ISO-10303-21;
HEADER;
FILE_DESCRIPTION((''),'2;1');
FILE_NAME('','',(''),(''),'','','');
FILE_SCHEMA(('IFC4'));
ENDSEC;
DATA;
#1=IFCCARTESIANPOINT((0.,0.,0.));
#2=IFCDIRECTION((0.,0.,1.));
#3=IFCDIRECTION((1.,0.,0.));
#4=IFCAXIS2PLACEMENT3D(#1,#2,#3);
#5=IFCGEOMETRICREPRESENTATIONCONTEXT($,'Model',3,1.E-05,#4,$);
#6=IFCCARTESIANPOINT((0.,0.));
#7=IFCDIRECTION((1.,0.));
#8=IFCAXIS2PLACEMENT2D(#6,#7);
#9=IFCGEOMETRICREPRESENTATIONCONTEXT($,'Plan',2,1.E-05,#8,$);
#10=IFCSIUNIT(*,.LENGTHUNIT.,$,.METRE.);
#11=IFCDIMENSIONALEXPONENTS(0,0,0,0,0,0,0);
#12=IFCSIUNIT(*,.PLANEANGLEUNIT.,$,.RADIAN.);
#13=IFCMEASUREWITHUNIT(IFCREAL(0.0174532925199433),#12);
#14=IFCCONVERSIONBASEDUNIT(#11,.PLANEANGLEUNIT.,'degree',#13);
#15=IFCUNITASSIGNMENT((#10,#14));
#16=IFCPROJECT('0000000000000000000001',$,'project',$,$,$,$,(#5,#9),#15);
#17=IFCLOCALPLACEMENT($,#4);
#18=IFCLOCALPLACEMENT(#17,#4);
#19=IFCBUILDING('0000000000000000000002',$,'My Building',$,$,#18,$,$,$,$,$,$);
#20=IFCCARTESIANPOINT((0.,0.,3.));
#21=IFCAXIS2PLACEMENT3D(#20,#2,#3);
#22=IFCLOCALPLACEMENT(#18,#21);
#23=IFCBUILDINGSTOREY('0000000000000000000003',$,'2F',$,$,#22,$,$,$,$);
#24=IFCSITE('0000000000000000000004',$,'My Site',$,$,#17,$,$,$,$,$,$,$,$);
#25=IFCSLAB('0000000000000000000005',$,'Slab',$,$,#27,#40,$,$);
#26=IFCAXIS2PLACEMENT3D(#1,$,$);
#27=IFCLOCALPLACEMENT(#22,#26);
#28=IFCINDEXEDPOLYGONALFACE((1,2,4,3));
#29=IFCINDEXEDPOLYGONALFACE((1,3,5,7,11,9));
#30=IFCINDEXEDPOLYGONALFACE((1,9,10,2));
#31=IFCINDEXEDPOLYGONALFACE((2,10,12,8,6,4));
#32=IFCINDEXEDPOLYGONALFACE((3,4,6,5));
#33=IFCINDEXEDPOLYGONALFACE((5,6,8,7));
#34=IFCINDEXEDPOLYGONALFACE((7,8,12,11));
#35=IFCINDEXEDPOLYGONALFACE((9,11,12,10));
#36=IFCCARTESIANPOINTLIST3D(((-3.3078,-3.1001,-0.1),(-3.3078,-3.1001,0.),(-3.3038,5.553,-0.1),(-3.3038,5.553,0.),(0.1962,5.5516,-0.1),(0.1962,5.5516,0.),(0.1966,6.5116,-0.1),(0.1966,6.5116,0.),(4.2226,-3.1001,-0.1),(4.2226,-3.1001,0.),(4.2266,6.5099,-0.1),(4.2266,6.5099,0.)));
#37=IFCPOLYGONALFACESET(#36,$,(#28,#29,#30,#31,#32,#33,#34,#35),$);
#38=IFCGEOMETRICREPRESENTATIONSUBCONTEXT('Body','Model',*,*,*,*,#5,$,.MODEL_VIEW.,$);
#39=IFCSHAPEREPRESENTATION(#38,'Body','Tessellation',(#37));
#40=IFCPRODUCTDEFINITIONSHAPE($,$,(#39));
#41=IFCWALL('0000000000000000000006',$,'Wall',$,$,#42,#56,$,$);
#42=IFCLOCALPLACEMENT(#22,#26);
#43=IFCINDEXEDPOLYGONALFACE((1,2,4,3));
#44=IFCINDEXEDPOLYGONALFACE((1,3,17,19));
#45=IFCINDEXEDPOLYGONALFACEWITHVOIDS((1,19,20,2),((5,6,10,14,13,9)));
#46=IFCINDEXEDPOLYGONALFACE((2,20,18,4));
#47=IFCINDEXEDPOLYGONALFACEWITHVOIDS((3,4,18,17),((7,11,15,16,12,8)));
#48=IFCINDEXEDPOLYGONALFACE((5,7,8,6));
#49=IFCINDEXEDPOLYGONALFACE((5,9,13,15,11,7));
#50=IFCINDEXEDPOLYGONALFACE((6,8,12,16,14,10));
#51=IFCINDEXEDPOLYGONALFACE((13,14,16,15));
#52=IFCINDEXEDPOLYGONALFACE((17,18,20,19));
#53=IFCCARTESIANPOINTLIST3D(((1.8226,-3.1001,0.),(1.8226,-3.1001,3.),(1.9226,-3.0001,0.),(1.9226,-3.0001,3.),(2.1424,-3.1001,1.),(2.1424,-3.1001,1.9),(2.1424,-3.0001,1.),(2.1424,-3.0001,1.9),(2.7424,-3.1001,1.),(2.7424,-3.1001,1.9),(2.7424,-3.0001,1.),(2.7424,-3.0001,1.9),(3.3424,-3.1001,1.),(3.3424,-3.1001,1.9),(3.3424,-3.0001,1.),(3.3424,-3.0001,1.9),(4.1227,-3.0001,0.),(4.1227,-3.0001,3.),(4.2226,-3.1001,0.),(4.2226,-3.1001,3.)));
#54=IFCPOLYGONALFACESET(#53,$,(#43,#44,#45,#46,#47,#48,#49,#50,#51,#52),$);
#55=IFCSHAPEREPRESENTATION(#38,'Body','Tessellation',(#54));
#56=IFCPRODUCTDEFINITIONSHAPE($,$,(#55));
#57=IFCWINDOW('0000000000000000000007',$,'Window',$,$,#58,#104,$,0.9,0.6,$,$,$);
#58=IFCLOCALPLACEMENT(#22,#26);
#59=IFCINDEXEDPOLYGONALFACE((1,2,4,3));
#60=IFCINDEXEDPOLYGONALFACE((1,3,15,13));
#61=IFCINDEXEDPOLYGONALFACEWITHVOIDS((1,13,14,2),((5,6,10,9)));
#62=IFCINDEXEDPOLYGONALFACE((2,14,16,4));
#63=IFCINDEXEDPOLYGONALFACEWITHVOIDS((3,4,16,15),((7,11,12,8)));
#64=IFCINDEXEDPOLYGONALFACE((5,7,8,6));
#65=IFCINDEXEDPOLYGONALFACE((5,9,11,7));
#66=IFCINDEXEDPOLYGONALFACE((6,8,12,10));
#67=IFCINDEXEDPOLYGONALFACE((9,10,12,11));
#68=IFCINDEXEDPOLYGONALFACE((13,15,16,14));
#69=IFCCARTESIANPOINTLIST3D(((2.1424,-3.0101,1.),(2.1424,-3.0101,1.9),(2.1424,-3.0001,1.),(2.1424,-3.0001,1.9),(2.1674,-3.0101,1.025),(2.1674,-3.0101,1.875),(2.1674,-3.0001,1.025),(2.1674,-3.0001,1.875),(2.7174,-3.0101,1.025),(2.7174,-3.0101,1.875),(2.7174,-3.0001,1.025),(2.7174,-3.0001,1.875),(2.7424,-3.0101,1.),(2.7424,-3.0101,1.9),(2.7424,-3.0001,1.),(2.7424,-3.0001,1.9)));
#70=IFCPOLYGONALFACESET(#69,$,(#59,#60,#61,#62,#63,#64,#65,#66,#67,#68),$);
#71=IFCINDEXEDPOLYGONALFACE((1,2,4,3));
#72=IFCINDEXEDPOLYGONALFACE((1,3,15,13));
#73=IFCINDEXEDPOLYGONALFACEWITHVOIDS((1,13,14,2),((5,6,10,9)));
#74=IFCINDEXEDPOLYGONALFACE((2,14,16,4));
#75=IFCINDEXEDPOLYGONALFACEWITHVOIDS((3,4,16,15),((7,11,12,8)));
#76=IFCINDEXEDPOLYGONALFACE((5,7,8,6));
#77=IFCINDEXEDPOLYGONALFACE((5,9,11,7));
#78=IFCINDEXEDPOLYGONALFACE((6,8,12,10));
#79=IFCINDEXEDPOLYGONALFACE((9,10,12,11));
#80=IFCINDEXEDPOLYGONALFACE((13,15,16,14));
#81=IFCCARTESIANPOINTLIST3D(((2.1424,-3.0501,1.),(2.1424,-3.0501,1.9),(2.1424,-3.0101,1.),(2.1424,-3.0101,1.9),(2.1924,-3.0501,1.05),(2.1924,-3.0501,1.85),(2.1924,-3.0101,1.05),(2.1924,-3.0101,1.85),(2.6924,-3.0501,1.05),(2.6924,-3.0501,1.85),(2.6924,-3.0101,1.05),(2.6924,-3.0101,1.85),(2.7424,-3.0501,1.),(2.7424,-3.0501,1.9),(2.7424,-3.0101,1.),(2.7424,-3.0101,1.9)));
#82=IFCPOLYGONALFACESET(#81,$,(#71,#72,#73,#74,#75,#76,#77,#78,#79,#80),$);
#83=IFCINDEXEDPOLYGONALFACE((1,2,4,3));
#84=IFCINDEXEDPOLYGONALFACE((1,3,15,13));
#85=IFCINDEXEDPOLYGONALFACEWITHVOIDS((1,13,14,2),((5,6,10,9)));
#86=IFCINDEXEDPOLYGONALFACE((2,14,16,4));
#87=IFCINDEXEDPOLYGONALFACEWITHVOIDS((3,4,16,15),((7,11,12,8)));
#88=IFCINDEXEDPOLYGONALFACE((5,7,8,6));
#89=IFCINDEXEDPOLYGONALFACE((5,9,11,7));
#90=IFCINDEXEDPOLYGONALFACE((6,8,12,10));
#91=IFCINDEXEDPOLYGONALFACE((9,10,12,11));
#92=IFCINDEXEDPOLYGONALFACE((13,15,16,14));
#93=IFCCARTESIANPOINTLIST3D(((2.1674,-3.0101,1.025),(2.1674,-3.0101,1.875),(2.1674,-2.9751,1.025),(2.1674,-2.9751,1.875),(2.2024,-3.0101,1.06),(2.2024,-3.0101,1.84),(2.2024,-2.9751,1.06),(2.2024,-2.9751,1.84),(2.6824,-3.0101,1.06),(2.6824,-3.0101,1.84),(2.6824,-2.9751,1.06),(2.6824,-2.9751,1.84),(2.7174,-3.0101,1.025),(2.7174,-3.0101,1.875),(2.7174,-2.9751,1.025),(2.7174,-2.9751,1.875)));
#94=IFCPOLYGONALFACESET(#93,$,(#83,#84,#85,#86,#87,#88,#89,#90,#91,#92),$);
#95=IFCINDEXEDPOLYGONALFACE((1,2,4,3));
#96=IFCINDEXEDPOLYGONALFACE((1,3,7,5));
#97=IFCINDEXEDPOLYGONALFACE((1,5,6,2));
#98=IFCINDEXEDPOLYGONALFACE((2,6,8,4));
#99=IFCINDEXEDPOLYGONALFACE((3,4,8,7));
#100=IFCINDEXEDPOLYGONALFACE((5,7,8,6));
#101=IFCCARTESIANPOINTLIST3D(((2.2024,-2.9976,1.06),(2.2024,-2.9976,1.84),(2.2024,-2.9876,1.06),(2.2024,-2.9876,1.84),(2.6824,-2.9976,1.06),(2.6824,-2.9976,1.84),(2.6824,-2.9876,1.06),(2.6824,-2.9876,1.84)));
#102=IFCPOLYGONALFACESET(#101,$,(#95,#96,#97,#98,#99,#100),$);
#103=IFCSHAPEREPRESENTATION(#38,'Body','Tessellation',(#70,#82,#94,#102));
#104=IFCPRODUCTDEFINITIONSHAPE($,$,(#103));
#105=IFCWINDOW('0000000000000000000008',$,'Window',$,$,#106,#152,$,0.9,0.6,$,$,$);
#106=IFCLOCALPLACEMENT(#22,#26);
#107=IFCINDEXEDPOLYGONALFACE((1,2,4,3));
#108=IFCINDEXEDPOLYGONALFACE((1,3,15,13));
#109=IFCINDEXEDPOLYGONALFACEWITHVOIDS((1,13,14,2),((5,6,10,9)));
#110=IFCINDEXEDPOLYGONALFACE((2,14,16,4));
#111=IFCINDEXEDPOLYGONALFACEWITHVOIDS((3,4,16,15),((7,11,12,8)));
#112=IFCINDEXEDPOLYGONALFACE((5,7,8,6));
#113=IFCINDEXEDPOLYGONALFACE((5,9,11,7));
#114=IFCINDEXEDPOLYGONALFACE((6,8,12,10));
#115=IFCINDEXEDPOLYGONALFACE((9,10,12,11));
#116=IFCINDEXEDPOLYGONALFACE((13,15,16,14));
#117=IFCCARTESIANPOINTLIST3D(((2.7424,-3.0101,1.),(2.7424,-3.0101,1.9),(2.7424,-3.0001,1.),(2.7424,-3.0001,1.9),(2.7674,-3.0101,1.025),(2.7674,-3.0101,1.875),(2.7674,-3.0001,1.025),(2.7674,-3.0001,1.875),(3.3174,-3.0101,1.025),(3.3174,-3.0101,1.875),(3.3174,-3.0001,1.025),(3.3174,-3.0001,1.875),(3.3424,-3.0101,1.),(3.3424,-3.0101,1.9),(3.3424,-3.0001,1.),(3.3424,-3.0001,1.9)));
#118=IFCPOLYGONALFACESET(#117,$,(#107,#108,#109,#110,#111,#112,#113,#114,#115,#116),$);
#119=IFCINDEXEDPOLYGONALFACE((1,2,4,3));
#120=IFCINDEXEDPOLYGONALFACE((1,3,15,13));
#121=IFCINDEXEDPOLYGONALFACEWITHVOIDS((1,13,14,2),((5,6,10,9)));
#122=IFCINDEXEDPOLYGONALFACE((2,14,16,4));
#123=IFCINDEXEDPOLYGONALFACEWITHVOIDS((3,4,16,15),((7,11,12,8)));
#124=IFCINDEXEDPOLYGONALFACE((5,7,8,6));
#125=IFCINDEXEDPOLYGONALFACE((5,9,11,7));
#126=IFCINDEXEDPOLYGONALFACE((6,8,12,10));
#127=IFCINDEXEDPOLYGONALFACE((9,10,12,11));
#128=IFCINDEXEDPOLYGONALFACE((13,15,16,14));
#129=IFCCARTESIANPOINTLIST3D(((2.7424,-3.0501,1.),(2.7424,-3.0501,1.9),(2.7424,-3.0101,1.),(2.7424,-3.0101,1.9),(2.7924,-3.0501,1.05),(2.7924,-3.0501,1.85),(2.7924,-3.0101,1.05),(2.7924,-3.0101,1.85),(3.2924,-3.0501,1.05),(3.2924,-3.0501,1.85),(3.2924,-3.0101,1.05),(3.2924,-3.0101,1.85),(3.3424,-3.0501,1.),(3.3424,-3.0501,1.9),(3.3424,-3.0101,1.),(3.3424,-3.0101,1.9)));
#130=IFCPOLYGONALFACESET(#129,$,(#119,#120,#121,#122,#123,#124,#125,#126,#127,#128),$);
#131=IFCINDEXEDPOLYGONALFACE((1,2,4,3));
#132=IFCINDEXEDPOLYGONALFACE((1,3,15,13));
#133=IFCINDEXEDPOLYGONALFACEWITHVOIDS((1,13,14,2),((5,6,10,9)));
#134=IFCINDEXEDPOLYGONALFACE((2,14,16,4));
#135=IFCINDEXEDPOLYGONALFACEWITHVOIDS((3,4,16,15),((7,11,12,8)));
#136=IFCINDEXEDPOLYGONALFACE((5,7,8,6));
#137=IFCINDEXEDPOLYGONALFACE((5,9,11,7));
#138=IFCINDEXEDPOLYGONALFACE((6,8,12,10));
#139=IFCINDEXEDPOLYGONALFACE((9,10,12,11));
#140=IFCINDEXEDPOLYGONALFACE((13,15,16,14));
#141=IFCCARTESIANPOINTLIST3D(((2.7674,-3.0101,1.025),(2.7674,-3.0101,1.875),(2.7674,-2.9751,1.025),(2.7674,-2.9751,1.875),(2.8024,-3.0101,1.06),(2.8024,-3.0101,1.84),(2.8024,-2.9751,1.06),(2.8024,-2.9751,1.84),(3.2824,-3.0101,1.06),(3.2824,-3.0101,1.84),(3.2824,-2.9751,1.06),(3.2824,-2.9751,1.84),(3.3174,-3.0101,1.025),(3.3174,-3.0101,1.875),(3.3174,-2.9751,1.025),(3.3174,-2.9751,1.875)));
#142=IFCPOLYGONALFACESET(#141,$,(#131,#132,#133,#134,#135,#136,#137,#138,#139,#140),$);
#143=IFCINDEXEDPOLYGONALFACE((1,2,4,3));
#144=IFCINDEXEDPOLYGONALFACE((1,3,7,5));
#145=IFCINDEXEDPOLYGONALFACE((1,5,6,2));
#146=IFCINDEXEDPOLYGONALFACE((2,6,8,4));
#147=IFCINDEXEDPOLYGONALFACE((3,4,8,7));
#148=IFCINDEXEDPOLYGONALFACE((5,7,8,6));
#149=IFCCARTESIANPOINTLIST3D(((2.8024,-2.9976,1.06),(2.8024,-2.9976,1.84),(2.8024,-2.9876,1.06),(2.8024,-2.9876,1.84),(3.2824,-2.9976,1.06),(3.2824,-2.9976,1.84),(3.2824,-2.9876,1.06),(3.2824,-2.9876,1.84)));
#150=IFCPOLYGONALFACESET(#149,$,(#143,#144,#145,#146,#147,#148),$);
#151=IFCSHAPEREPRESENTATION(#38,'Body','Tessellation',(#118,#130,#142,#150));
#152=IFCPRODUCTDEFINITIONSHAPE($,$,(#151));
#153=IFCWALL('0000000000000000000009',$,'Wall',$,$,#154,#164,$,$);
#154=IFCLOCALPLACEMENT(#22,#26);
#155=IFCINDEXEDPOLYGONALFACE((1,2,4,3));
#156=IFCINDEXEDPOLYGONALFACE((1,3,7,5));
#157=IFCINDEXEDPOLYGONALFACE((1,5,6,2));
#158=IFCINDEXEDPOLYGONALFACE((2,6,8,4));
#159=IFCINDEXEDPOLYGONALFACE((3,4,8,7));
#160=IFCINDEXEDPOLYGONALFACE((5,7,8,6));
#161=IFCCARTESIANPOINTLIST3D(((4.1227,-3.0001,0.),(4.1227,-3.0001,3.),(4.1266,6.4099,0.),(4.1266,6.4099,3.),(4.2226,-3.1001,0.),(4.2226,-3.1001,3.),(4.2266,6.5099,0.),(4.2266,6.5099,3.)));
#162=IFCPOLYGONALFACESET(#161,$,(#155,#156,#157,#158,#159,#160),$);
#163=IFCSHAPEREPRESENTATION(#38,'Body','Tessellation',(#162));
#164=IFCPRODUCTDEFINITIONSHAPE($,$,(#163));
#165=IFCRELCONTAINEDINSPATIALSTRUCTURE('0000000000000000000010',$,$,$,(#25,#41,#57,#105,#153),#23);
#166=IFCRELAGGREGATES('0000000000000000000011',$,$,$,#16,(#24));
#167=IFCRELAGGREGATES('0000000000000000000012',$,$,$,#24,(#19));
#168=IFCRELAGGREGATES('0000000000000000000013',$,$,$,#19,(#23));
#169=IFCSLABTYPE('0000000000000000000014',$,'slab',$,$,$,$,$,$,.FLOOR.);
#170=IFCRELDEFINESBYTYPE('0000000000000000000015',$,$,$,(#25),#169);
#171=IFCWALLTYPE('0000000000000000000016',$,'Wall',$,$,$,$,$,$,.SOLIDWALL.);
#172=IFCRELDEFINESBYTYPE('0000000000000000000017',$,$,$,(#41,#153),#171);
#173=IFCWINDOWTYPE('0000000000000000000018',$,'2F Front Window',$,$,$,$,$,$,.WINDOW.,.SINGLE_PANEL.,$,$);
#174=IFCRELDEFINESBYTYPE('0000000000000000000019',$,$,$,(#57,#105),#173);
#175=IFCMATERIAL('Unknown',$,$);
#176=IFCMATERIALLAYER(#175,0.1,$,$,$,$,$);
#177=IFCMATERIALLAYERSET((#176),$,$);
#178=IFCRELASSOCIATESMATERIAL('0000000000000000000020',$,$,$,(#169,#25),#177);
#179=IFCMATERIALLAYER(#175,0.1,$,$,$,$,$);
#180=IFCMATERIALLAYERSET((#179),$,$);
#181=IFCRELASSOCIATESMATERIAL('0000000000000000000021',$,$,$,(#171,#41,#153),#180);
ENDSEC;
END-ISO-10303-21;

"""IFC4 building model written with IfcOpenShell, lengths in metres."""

from ifc_helpers import new_model, entity, si_unit, converted_unit, frame, origin_with_axes, origin_2d_with_axis, place, context, subcontext, project, spatial, line, indexed_curve, outline, extrude, shape, source, transform, mapped, material, layer, layer_set, layer_usage, type_object, type_shapes, element, fill, save


model = new_model("IFC4")

# Units and contexts
model_context = context("Model", 3, precision=1e-05, world=origin_with_axes())
plan_context = context("Plan", 2, precision=1e-05, world=origin_2d_with_axis())
body_context_1 = subcontext(model_context, "Body", "Model", "MODEL_VIEW")
body_context_2 = subcontext(plan_context, "Body", "Plan", "PLAN_VIEW")
ifc_project = project(units=[si_unit("LENGTHUNIT", "METRE"), converted_unit("PLANEANGLEUNIT", "degree", entity("IfcReal", 0.0174532925199433), si_unit("PLANEANGLEUNIT", "RADIAN"), dimensions=[0, 0, 0, 0, 0, 0, 0])], contexts=[model_context, plan_context])

# Site, building, storey
site_placement = place(None, origin_with_axes())
site = spatial("IfcSite", under=ifc_project, at=site_placement, Name="My Site")
building_placement = place(site_placement, origin_with_axes())
building = spatial("IfcBuilding", under=site, at=building_placement, Name="My Building")
storey_placement = place(building_placement, frame((0.0, 0.0, 3.0), z_axis=(0.0, 0.0, 1.0), x_axis=(1.0, 0.0, 0.0)))
storey = spatial("IfcBuildingStorey", under=building, at=storey_placement, Name="2F")

# Slab
ifc_material = material(Name="Unknown")
ifc_layer_1 = layer(ifc_material, 0.1)
ifc_layer_set_1 = layer_set([ifc_layer_1])
ifc_layer_usage_1 = layer_usage(ifc_layer_set_1, "AXIS3", "POSITIVE", -0.1)
slab_type = type_object("IfcSlabType", Name="slab", PredefinedType="FLOOR", material=ifc_layer_set_1)
slab_placement = place(storey_placement, frame((-3.3078, -3.1001, 0.0), z_axis=(0.0, 0.0, 1.0), x_axis=(1.0, 0.0, 0.0)))
element("IfcSlab", 1, at=slab_placement, inside=storey, type_object=slab_type, material=ifc_layer_usage_1, Name="Slab", context=body_context_1, shape_type="SweptSolid", body=[
    extrude(outline(indexed_curve([(0.0, 0.0), (7.5304, 0.0), (7.5344, 9.61), (3.5044, 9.6117), (3.504, 8.6517), (0.004, 8.6531), (0.0, 0.0)])), frame((0.0, 0.0, -0.1), z_axis=(0.0, 0.0, 1.0), x_axis=(1.0, 0.0, 0.0)), (0.0, 0.0, 1.0), 0.1),
])

# Wall, openings, windows
ifc_layer_2 = layer(ifc_material, 0.1)
ifc_layer_set_2 = layer_set([ifc_layer_2])
ifc_layer_usage_2 = layer_usage(ifc_layer_set_2, "AXIS2", "POSITIVE", 0.0)
wall_type = type_object("IfcWallType", Name="Wall", PredefinedType="SOLIDWALL", material=ifc_layer_set_2)
wall_1_placement = place(storey_placement, frame((1.8226, -3.1001, 0.0), z_axis=(0.0, 0.0, 1.0), x_axis=(1.0, 0.0, 0.0)))
wall_1 = element("IfcWall", 2, at=wall_1_placement, inside=storey, type_object=wall_type, material=ifc_layer_usage_2, Name="Wall", context=body_context_1, shape_type="SweptSolid", body=[
    extrude(outline(indexed_curve([(0.0, 0.0), (0.1, 0.1), (2.3, 0.1), (2.4, 0.0)], segments=[line(1, 2, 3, 4, 1)])), origin_with_axes(), (0.0, 0.0, 1.0), 3.0),
])
shared_shape_1 = source(origin_with_axes(), body_context_1, "Body", "SweptSolid", [
    extrude(outline(indexed_curve([(0.0, 0.0), (0.6, 0.0), (0.6, 0.9), (0.0, 0.9)], segments=[line(1, 2, 3, 4, 1)])), frame((0.0, -0.6, 0.0), z_axis=(0.0, -1.0, 0.0), x_axis=(1.0, 0.0, 0.0)), (0.0, 0.0, -1.0), 1.2),
])
opening_1_placement = place(wall_1_placement, frame((0.3197, 0.0, 1.0), z_axis=(0.0, 0.0, 1.0), x_axis=(1.0, 0.0, 0.0)))
opening_1 = element("IfcOpeningElement", 3, at=opening_1_placement, cuts=wall_1, PredefinedType="OPENING", context=body_context_1, shape_type="MappedRepresentation", body=[
    mapped(shared_shape_1, transform((0.0, 0.0, 0.0), x_axis=(1.0, 0.0, 0.0), y_axis=(0.0, 1.0, 0.0), z_axis=(0.0, 0.0, 1.0), scale=1.0)),
])
opening_2_placement = place(wall_1_placement, frame((0.9197, 0.0, 1.0), z_axis=(0.0, 0.0, 1.0), x_axis=(1.0, 0.0, 0.0)))
opening_2 = element("IfcOpeningElement", 4, at=opening_2_placement, cuts=wall_1, PredefinedType="OPENING", context=body_context_1, shape_type="MappedRepresentation", body=[
    mapped(shared_shape_1, transform((0.0, 0.0, 0.0), x_axis=(1.0, 0.0, 0.0), y_axis=(0.0, 1.0, 0.0), z_axis=(0.0, 0.0, 1.0), scale=1.0)),
])
window_type = type_object("IfcWindowType", Name="2F Front Window", PartitioningType="SINGLE_PANEL", PredefinedType="WINDOW")
shared_shape_2 = source(origin_with_axes(), body_context_1, "Body", "SweptSolid", [
    extrude(outline(indexed_curve([(0.0, 0.0), (0.6, 0.0), (0.6, 0.9), (0.0, 0.9)], segments=[line(1, 2, 3, 4, 1)]), holes=[indexed_curve([(0.025, 0.025), (0.575, 0.025), (0.575, 0.875), (0.025, 0.875)], segments=[line(1, 2, 3, 4, 1)])]), frame((0.0, 0.09, 0.0), z_axis=(0.0, -1.0, 0.0), x_axis=(1.0, 0.0, 0.0)), (0.0, 0.0, -1.0), 0.01),
    extrude(outline(indexed_curve([(0.0, 0.0), (0.6, 0.0), (0.6, 0.9), (0.0, 0.9)], segments=[line(1, 2, 3, 4, 1)]), holes=[indexed_curve([(0.05, 0.05), (0.55, 0.05), (0.55, 0.85), (0.05, 0.85)], segments=[line(1, 2, 3, 4, 1)])]), frame((0.0, 0.05, 0.0), z_axis=(0.0, -1.0, 0.0), x_axis=(1.0, 0.0, 0.0)), (0.0, 0.0, -1.0), 0.04),
    extrude(outline(indexed_curve([(0.0, 0.0), (0.55, 0.0), (0.55, 0.85), (0.0, 0.85)], segments=[line(1, 2, 3, 4, 1)]), holes=[indexed_curve([(0.035, 0.035), (0.515, 0.035), (0.515, 0.815), (0.035, 0.815)], segments=[line(1, 2, 3, 4, 1)])]), frame((0.025, 0.09, 0.025), z_axis=(0.0, -1.0, 0.0), x_axis=(1.0, 0.0, 0.0)), (0.0, 0.0, -1.0), 0.035),
    extrude(outline(indexed_curve([(0.035, 0.035), (0.515, 0.035), (0.515, 0.815), (0.035, 0.815)], segments=[line(1, 2, 3, 4, 1)])), frame((0.025, 0.1025, 0.025), z_axis=(0.0, -1.0, 0.0), x_axis=(1.0, 0.0, 0.0)), (0.0, 0.0, -1.0), 0.01),
])
shared_shape_3 = source(origin_with_axes(), body_context_2, "Body", "Curve2D", [
    entity("IfcIndexedPolyCurve", entity("IfcCartesianPointList2D", [[0.05, 0.05], [0.55, 0.05]])),
    entity("IfcIndexedPolyCurve", entity("IfcCartesianPointList2D", [[0.0, 0.1], [0.025, 0.1], [0.025, 0.09], [0.05, 0.09], [0.05, 0.05], [0.0, 0.05]]), [entity("IfcLineIndex", [1, 2, 3, 4, 5, 6, 1])]),
    entity("IfcIndexedPolyCurve", entity("IfcCartesianPointList2D", [[0.6, 0.1], [0.575, 0.1], [0.575, 0.09], [0.55, 0.09], [0.55, 0.05], [0.6, 0.05]]), [entity("IfcLineIndex", [1, 2, 3, 4, 5, 6, 1])]),
    entity("IfcIndexedPolyCurve", entity("IfcCartesianPointList2D", [[0.025, 0.09], [0.06, 0.09], [0.06, 0.125], [0.025, 0.125]]), [entity("IfcLineIndex", [1, 2, 3, 4, 1])]),
    entity("IfcIndexedPolyCurve", entity("IfcCartesianPointList2D", [[0.575, 0.09], [0.54, 0.09], [0.54, 0.125], [0.575, 0.125]]), [entity("IfcLineIndex", [1, 2, 3, 4, 1])]),
    entity("IfcIndexedPolyCurve", entity("IfcCartesianPointList2D", [[0.06, 0.09], [0.54, 0.09]])),
    entity("IfcIndexedPolyCurve", entity("IfcCartesianPointList2D", [[0.06, 0.125], [0.54, 0.125]])),
    entity("IfcIndexedPolyCurve", entity("IfcCartesianPointList2D", [[0.06, 0.1075], [0.54, 0.1075]])),
])
type_shapes(window_type, [shared_shape_2, shared_shape_3])
window_1_placement = place(opening_1_placement, origin_with_axes())
window_1 = element("IfcWindow", 5, at=window_1_placement, inside=storey, type_object=window_type, Name="Window", OverallHeight=0.9, OverallWidth=0.6, shapes=[
    shape(body_context_1, "Body", "MappedRepresentation", [mapped(shared_shape_2, transform((0.0, 0.0, 0.0), x_axis=(1.0, 0.0, 0.0), y_axis=(0.0, 1.0, 0.0), z_axis=(0.0, 0.0, 1.0), scale=1.0))]),
    shape(body_context_2, "Body", "MappedRepresentation", [mapped(shared_shape_3, transform((0.0, 0.0, 0.0), x_axis=(1.0, 0.0, 0.0), y_axis=(0.0, 1.0, 0.0), z_axis=(0.0, 0.0, 1.0), scale=1.0))]),
])
fill(opening_1, window_1)
window_2_placement = place(opening_2_placement, origin_with_axes())
window_2 = element("IfcWindow", 6, at=window_2_placement, inside=storey, type_object=window_type, Name="Window", OverallHeight=0.9, OverallWidth=0.6, shapes=[
    shape(body_context_1, "Body", "MappedRepresentation", [mapped(shared_shape_2, transform((0.0, 0.0, 0.0), x_axis=(1.0, 0.0, 0.0), y_axis=(0.0, 1.0, 0.0), z_axis=(0.0, 0.0, 1.0), scale=1.0))]),
    shape(body_context_2, "Body", "MappedRepresentation", [mapped(shared_shape_3, transform((0.0, 0.0, 0.0), x_axis=(1.0, 0.0, 0.0), y_axis=(0.0, 1.0, 0.0), z_axis=(0.0, 0.0, 1.0), scale=1.0))]),
])
fill(opening_2, window_2)

# Wall
ifc_layer_usage_3 = layer_usage(ifc_layer_set_2, "AXIS2", "POSITIVE", 0.0)
wall_2_placement = place(storey_placement, frame((4.2226, -3.1001, 0.0), z_axis=(0.0, 0.0, 1.0), x_axis=(0.000415, 1.0, 0.0)))
element("IfcWall", 7, at=wall_2_placement, inside=storey, type_object=wall_type, material=ifc_layer_usage_3, Name="Wall", context=body_context_1, shape_type="SweptSolid", body=[
    extrude(outline(indexed_curve([(0.0, 0.0), (0.1, 0.1), (9.51, 0.1), (9.61, 0.0)], segments=[line(1, 2, 3, 4, 1)])), origin_with_axes(), (0.0, 0.0, 1.0), 3.0),
])

save(model, "model.ifc")
